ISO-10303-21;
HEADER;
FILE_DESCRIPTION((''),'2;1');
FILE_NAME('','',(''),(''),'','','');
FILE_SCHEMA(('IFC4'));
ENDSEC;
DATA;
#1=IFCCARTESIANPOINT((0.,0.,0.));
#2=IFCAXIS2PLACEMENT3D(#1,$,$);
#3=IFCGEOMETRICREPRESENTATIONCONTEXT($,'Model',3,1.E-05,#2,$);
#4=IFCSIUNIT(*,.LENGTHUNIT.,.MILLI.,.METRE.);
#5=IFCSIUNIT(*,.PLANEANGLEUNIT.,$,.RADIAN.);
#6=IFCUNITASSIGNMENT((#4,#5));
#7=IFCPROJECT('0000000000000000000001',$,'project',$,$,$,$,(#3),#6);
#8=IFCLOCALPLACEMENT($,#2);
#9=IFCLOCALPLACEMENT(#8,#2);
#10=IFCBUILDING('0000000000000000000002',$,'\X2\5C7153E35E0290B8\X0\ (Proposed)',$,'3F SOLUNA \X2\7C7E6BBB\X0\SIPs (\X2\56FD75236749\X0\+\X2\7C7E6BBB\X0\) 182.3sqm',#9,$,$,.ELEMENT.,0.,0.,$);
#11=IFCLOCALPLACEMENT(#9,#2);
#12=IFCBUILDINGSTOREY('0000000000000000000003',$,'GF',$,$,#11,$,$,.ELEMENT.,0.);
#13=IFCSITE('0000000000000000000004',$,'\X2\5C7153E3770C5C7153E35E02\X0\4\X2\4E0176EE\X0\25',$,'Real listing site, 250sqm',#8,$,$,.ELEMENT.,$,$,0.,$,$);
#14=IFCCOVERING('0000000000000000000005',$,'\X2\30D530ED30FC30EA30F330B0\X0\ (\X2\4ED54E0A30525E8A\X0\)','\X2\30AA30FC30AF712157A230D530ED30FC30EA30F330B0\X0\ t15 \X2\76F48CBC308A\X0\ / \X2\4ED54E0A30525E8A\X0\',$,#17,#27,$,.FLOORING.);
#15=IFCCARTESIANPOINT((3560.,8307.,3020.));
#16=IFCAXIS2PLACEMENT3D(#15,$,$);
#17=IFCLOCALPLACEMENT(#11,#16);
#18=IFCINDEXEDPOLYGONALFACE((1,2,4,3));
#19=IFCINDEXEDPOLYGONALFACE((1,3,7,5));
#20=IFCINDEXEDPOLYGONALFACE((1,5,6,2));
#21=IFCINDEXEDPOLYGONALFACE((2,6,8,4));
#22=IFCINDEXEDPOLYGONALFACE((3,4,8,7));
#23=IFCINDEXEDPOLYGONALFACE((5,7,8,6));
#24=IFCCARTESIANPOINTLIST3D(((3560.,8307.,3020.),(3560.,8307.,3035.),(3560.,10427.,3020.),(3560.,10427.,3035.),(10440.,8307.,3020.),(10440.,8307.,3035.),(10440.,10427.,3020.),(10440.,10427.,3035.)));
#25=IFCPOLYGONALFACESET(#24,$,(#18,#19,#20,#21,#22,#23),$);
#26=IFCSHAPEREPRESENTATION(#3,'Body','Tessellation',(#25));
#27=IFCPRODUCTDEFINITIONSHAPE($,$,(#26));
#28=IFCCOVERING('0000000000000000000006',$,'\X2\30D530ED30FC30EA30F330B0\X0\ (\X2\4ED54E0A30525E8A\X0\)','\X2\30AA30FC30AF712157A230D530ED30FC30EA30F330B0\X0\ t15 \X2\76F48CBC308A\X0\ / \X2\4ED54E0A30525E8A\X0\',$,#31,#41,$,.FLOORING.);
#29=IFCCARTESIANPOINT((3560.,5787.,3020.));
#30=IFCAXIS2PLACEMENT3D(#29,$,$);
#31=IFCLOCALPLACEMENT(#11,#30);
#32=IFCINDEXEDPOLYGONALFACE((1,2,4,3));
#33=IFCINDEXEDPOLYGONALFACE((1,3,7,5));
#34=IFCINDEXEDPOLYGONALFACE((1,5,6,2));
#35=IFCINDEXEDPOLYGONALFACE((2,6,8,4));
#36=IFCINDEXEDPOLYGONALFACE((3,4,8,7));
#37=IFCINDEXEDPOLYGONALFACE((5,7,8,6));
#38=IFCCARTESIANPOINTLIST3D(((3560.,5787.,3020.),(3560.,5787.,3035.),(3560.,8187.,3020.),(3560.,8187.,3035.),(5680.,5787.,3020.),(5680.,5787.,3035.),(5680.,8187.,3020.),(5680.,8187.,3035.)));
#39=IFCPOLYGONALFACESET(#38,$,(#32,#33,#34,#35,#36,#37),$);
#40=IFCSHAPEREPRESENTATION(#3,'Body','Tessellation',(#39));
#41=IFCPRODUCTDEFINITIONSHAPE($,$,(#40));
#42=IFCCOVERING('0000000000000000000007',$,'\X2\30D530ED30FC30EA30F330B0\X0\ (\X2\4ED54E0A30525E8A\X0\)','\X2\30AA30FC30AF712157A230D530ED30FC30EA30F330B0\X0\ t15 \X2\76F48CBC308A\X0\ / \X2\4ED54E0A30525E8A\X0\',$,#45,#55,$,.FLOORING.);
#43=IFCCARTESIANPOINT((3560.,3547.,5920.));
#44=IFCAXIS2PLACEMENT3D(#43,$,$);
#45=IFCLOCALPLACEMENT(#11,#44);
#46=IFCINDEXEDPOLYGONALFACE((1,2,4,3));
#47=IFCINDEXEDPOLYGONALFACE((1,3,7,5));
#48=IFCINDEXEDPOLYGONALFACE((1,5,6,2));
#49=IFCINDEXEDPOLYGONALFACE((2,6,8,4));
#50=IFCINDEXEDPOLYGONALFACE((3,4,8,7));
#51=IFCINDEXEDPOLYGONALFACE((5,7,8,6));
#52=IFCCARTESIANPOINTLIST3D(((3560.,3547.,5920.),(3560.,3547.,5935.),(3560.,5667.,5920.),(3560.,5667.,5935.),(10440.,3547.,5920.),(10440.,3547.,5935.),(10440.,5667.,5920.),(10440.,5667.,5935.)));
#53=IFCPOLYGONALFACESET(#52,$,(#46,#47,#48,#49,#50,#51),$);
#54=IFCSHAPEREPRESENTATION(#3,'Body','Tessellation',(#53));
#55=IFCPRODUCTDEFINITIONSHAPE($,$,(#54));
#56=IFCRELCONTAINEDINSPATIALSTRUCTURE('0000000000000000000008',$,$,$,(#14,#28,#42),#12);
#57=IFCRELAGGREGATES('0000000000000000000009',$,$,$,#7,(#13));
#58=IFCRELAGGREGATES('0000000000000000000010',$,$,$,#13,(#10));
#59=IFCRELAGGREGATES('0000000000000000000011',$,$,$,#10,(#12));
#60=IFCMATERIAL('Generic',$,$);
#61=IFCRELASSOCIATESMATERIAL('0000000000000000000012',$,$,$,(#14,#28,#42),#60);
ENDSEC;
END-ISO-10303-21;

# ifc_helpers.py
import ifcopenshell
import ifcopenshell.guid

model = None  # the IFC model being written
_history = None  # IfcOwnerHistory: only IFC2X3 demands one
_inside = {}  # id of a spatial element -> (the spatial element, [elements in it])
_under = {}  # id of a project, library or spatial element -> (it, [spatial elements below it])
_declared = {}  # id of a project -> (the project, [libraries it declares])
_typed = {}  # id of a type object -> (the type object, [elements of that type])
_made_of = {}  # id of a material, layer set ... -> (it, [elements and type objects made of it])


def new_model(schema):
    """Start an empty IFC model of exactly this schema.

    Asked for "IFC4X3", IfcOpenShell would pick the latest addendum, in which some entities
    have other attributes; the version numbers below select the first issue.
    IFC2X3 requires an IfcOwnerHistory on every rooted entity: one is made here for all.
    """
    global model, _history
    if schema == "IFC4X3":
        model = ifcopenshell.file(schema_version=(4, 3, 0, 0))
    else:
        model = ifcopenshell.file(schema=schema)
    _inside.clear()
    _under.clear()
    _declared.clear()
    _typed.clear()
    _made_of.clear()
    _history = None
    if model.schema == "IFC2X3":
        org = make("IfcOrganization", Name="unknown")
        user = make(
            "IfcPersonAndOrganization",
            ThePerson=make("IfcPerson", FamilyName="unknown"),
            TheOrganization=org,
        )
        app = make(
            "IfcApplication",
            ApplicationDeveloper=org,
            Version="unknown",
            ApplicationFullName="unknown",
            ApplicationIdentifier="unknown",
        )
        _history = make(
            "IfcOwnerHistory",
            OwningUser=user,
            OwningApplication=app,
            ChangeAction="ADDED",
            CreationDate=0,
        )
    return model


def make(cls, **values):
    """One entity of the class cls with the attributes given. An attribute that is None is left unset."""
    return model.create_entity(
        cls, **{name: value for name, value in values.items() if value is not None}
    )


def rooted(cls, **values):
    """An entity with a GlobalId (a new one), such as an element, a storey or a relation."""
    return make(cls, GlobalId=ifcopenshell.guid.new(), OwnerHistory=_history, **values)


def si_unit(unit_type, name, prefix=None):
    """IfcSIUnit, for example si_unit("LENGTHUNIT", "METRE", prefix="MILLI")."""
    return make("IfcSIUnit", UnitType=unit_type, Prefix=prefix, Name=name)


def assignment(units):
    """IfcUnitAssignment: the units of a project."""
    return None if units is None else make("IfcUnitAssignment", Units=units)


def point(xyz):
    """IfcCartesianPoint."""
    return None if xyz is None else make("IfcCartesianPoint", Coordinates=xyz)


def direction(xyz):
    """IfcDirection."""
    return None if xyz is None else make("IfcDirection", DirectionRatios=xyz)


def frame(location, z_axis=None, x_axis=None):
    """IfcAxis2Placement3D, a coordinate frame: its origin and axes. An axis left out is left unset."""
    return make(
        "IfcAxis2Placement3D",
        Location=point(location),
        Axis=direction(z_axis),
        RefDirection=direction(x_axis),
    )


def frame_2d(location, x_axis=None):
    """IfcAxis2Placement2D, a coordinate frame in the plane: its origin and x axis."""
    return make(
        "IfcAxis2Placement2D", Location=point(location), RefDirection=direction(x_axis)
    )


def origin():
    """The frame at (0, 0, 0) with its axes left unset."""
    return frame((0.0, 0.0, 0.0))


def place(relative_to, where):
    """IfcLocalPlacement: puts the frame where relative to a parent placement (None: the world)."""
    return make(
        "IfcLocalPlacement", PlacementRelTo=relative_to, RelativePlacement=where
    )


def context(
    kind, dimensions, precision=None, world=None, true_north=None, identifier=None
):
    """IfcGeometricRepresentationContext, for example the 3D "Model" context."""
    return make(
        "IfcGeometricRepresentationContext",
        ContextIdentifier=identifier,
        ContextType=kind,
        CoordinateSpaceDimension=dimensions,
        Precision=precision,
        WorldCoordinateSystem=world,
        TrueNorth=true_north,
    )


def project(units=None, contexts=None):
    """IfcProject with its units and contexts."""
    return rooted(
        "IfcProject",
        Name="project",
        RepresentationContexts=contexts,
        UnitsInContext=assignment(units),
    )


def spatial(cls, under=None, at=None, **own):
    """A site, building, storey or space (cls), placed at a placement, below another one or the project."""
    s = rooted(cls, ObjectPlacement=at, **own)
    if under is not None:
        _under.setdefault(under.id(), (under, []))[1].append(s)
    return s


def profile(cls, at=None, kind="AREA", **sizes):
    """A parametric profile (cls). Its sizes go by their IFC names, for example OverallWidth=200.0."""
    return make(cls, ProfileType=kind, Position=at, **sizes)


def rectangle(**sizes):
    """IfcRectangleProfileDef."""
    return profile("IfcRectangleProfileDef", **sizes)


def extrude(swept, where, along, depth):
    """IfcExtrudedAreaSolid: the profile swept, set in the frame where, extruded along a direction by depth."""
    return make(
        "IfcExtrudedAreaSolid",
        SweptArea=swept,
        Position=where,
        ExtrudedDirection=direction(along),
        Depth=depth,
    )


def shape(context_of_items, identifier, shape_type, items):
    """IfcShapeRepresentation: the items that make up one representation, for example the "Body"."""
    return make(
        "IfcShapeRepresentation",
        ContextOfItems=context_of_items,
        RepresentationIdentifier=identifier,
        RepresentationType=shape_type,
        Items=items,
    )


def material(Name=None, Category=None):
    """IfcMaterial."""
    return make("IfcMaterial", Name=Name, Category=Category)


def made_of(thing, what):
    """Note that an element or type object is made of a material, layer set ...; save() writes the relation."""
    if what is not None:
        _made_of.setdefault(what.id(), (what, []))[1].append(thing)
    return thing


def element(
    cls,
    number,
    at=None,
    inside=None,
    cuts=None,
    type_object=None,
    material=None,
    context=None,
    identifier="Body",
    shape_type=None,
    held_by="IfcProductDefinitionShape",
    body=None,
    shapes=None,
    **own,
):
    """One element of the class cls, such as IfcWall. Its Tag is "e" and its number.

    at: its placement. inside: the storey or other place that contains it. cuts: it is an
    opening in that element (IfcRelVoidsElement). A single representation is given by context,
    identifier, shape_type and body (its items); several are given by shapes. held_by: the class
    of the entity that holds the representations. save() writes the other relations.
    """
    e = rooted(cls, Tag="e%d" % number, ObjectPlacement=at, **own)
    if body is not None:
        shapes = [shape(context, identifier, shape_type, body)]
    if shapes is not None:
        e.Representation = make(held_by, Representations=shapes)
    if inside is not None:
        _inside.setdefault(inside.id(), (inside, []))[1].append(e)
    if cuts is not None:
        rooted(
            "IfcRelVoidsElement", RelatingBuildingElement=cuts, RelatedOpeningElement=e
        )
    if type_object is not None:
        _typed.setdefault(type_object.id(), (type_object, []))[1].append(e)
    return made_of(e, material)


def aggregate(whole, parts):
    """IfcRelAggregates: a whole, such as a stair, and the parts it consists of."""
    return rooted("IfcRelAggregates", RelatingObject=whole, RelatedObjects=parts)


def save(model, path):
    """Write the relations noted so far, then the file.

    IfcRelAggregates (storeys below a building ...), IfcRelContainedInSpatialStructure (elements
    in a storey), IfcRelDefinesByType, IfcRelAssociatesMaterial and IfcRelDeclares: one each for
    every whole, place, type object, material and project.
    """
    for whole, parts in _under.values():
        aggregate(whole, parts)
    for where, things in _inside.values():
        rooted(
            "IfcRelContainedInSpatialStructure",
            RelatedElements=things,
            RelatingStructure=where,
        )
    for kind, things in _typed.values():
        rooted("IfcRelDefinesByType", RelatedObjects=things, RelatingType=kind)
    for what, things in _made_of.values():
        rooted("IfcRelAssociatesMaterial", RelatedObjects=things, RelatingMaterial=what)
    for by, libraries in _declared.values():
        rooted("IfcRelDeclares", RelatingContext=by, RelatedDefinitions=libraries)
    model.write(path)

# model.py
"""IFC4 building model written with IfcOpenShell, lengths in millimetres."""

from ifc_helpers import new_model, si_unit, frame, frame_2d, origin, place, context, project, spatial, rectangle, extrude, material, element, save


model = new_model("IFC4")

# Units and contexts
model_context = context("Model", 3, precision=1e-05, world=origin())
ifc_project = project(units=[si_unit("LENGTHUNIT", "METRE", prefix="MILLI"), si_unit("PLANEANGLEUNIT", "RADIAN")], contexts=[model_context])

# Site, building, storey
site_placement = place(None, origin())
site = spatial("IfcSite", under=ifc_project, at=site_placement, Name="山口県山口市4丁目25", ObjectType="Real listing site, 250sqm", CompositionType="ELEMENT", RefElevation=0.0)
building_placement = place(site_placement, origin())
building = spatial("IfcBuilding", under=site, at=building_placement, Name="山口市邸 (Proposed)", ObjectType="3F SOLUNA 籾殻SIPs (国産杉+籾殻) 182.3sqm", CompositionType="ELEMENT", ElevationOfRefHeight=0.0, ElevationOfTerrain=0.0)
storey_placement = place(building_placement, origin())
storey = spatial("IfcBuildingStorey", under=building, at=storey_placement, Name="GF", CompositionType="ELEMENT", Elevation=0.0)

# Shared definitions
ifc_material_1 = material(Name="Generic")

# Coverings
covering_1_placement = place(storey_placement, frame((3560.0, 8307.0, 3020.0)))
element("IfcCovering", 1, at=covering_1_placement, inside=storey, material=ifc_material_1, Name="フローリング (仕上げ床)", Description="オーク無垢フローリング t15 直貼り / 仕上げ床", PredefinedType="FLOORING", context=model_context, shape_type="SweptSolid", body=[
    extrude(rectangle(XDim=6880.0, YDim=2120.0, at=frame_2d((3440.0, 1060.0))), frame((3560.0, 8307.0, 3020.0)), (0.0, 0.0, 1.0), 15.0),
])
covering_2_placement = place(storey_placement, frame((3560.0, 5787.0, 3020.0)))
element("IfcCovering", 2, at=covering_2_placement, inside=storey, material=ifc_material_1, Name="フローリング (仕上げ床)", Description="オーク無垢フローリング t15 直貼り / 仕上げ床", PredefinedType="FLOORING", context=model_context, shape_type="SweptSolid", body=[
    extrude(rectangle(XDim=2120.0, YDim=2400.0, at=frame_2d((1060.0, 1200.0))), frame((3560.0, 5787.0, 3020.0)), (0.0, 0.0, 1.0), 15.0),
])
covering_3_placement = place(storey_placement, frame((3560.0, 3547.0, 5920.0)))
element("IfcCovering", 3, at=covering_3_placement, inside=storey, material=ifc_material_1, Name="フローリング (仕上げ床)", Description="オーク無垢フローリング t15 直貼り / 仕上げ床", PredefinedType="FLOORING", context=model_context, shape_type="SweptSolid", body=[
    extrude(rectangle(XDim=6880.0, YDim=2120.0, at=frame_2d((3440.0, 1060.0))), frame((3560.0, 3547.0, 5920.0)), (0.0, 0.0, 1.0), 15.0),
])

save(model, "model.ifc")
